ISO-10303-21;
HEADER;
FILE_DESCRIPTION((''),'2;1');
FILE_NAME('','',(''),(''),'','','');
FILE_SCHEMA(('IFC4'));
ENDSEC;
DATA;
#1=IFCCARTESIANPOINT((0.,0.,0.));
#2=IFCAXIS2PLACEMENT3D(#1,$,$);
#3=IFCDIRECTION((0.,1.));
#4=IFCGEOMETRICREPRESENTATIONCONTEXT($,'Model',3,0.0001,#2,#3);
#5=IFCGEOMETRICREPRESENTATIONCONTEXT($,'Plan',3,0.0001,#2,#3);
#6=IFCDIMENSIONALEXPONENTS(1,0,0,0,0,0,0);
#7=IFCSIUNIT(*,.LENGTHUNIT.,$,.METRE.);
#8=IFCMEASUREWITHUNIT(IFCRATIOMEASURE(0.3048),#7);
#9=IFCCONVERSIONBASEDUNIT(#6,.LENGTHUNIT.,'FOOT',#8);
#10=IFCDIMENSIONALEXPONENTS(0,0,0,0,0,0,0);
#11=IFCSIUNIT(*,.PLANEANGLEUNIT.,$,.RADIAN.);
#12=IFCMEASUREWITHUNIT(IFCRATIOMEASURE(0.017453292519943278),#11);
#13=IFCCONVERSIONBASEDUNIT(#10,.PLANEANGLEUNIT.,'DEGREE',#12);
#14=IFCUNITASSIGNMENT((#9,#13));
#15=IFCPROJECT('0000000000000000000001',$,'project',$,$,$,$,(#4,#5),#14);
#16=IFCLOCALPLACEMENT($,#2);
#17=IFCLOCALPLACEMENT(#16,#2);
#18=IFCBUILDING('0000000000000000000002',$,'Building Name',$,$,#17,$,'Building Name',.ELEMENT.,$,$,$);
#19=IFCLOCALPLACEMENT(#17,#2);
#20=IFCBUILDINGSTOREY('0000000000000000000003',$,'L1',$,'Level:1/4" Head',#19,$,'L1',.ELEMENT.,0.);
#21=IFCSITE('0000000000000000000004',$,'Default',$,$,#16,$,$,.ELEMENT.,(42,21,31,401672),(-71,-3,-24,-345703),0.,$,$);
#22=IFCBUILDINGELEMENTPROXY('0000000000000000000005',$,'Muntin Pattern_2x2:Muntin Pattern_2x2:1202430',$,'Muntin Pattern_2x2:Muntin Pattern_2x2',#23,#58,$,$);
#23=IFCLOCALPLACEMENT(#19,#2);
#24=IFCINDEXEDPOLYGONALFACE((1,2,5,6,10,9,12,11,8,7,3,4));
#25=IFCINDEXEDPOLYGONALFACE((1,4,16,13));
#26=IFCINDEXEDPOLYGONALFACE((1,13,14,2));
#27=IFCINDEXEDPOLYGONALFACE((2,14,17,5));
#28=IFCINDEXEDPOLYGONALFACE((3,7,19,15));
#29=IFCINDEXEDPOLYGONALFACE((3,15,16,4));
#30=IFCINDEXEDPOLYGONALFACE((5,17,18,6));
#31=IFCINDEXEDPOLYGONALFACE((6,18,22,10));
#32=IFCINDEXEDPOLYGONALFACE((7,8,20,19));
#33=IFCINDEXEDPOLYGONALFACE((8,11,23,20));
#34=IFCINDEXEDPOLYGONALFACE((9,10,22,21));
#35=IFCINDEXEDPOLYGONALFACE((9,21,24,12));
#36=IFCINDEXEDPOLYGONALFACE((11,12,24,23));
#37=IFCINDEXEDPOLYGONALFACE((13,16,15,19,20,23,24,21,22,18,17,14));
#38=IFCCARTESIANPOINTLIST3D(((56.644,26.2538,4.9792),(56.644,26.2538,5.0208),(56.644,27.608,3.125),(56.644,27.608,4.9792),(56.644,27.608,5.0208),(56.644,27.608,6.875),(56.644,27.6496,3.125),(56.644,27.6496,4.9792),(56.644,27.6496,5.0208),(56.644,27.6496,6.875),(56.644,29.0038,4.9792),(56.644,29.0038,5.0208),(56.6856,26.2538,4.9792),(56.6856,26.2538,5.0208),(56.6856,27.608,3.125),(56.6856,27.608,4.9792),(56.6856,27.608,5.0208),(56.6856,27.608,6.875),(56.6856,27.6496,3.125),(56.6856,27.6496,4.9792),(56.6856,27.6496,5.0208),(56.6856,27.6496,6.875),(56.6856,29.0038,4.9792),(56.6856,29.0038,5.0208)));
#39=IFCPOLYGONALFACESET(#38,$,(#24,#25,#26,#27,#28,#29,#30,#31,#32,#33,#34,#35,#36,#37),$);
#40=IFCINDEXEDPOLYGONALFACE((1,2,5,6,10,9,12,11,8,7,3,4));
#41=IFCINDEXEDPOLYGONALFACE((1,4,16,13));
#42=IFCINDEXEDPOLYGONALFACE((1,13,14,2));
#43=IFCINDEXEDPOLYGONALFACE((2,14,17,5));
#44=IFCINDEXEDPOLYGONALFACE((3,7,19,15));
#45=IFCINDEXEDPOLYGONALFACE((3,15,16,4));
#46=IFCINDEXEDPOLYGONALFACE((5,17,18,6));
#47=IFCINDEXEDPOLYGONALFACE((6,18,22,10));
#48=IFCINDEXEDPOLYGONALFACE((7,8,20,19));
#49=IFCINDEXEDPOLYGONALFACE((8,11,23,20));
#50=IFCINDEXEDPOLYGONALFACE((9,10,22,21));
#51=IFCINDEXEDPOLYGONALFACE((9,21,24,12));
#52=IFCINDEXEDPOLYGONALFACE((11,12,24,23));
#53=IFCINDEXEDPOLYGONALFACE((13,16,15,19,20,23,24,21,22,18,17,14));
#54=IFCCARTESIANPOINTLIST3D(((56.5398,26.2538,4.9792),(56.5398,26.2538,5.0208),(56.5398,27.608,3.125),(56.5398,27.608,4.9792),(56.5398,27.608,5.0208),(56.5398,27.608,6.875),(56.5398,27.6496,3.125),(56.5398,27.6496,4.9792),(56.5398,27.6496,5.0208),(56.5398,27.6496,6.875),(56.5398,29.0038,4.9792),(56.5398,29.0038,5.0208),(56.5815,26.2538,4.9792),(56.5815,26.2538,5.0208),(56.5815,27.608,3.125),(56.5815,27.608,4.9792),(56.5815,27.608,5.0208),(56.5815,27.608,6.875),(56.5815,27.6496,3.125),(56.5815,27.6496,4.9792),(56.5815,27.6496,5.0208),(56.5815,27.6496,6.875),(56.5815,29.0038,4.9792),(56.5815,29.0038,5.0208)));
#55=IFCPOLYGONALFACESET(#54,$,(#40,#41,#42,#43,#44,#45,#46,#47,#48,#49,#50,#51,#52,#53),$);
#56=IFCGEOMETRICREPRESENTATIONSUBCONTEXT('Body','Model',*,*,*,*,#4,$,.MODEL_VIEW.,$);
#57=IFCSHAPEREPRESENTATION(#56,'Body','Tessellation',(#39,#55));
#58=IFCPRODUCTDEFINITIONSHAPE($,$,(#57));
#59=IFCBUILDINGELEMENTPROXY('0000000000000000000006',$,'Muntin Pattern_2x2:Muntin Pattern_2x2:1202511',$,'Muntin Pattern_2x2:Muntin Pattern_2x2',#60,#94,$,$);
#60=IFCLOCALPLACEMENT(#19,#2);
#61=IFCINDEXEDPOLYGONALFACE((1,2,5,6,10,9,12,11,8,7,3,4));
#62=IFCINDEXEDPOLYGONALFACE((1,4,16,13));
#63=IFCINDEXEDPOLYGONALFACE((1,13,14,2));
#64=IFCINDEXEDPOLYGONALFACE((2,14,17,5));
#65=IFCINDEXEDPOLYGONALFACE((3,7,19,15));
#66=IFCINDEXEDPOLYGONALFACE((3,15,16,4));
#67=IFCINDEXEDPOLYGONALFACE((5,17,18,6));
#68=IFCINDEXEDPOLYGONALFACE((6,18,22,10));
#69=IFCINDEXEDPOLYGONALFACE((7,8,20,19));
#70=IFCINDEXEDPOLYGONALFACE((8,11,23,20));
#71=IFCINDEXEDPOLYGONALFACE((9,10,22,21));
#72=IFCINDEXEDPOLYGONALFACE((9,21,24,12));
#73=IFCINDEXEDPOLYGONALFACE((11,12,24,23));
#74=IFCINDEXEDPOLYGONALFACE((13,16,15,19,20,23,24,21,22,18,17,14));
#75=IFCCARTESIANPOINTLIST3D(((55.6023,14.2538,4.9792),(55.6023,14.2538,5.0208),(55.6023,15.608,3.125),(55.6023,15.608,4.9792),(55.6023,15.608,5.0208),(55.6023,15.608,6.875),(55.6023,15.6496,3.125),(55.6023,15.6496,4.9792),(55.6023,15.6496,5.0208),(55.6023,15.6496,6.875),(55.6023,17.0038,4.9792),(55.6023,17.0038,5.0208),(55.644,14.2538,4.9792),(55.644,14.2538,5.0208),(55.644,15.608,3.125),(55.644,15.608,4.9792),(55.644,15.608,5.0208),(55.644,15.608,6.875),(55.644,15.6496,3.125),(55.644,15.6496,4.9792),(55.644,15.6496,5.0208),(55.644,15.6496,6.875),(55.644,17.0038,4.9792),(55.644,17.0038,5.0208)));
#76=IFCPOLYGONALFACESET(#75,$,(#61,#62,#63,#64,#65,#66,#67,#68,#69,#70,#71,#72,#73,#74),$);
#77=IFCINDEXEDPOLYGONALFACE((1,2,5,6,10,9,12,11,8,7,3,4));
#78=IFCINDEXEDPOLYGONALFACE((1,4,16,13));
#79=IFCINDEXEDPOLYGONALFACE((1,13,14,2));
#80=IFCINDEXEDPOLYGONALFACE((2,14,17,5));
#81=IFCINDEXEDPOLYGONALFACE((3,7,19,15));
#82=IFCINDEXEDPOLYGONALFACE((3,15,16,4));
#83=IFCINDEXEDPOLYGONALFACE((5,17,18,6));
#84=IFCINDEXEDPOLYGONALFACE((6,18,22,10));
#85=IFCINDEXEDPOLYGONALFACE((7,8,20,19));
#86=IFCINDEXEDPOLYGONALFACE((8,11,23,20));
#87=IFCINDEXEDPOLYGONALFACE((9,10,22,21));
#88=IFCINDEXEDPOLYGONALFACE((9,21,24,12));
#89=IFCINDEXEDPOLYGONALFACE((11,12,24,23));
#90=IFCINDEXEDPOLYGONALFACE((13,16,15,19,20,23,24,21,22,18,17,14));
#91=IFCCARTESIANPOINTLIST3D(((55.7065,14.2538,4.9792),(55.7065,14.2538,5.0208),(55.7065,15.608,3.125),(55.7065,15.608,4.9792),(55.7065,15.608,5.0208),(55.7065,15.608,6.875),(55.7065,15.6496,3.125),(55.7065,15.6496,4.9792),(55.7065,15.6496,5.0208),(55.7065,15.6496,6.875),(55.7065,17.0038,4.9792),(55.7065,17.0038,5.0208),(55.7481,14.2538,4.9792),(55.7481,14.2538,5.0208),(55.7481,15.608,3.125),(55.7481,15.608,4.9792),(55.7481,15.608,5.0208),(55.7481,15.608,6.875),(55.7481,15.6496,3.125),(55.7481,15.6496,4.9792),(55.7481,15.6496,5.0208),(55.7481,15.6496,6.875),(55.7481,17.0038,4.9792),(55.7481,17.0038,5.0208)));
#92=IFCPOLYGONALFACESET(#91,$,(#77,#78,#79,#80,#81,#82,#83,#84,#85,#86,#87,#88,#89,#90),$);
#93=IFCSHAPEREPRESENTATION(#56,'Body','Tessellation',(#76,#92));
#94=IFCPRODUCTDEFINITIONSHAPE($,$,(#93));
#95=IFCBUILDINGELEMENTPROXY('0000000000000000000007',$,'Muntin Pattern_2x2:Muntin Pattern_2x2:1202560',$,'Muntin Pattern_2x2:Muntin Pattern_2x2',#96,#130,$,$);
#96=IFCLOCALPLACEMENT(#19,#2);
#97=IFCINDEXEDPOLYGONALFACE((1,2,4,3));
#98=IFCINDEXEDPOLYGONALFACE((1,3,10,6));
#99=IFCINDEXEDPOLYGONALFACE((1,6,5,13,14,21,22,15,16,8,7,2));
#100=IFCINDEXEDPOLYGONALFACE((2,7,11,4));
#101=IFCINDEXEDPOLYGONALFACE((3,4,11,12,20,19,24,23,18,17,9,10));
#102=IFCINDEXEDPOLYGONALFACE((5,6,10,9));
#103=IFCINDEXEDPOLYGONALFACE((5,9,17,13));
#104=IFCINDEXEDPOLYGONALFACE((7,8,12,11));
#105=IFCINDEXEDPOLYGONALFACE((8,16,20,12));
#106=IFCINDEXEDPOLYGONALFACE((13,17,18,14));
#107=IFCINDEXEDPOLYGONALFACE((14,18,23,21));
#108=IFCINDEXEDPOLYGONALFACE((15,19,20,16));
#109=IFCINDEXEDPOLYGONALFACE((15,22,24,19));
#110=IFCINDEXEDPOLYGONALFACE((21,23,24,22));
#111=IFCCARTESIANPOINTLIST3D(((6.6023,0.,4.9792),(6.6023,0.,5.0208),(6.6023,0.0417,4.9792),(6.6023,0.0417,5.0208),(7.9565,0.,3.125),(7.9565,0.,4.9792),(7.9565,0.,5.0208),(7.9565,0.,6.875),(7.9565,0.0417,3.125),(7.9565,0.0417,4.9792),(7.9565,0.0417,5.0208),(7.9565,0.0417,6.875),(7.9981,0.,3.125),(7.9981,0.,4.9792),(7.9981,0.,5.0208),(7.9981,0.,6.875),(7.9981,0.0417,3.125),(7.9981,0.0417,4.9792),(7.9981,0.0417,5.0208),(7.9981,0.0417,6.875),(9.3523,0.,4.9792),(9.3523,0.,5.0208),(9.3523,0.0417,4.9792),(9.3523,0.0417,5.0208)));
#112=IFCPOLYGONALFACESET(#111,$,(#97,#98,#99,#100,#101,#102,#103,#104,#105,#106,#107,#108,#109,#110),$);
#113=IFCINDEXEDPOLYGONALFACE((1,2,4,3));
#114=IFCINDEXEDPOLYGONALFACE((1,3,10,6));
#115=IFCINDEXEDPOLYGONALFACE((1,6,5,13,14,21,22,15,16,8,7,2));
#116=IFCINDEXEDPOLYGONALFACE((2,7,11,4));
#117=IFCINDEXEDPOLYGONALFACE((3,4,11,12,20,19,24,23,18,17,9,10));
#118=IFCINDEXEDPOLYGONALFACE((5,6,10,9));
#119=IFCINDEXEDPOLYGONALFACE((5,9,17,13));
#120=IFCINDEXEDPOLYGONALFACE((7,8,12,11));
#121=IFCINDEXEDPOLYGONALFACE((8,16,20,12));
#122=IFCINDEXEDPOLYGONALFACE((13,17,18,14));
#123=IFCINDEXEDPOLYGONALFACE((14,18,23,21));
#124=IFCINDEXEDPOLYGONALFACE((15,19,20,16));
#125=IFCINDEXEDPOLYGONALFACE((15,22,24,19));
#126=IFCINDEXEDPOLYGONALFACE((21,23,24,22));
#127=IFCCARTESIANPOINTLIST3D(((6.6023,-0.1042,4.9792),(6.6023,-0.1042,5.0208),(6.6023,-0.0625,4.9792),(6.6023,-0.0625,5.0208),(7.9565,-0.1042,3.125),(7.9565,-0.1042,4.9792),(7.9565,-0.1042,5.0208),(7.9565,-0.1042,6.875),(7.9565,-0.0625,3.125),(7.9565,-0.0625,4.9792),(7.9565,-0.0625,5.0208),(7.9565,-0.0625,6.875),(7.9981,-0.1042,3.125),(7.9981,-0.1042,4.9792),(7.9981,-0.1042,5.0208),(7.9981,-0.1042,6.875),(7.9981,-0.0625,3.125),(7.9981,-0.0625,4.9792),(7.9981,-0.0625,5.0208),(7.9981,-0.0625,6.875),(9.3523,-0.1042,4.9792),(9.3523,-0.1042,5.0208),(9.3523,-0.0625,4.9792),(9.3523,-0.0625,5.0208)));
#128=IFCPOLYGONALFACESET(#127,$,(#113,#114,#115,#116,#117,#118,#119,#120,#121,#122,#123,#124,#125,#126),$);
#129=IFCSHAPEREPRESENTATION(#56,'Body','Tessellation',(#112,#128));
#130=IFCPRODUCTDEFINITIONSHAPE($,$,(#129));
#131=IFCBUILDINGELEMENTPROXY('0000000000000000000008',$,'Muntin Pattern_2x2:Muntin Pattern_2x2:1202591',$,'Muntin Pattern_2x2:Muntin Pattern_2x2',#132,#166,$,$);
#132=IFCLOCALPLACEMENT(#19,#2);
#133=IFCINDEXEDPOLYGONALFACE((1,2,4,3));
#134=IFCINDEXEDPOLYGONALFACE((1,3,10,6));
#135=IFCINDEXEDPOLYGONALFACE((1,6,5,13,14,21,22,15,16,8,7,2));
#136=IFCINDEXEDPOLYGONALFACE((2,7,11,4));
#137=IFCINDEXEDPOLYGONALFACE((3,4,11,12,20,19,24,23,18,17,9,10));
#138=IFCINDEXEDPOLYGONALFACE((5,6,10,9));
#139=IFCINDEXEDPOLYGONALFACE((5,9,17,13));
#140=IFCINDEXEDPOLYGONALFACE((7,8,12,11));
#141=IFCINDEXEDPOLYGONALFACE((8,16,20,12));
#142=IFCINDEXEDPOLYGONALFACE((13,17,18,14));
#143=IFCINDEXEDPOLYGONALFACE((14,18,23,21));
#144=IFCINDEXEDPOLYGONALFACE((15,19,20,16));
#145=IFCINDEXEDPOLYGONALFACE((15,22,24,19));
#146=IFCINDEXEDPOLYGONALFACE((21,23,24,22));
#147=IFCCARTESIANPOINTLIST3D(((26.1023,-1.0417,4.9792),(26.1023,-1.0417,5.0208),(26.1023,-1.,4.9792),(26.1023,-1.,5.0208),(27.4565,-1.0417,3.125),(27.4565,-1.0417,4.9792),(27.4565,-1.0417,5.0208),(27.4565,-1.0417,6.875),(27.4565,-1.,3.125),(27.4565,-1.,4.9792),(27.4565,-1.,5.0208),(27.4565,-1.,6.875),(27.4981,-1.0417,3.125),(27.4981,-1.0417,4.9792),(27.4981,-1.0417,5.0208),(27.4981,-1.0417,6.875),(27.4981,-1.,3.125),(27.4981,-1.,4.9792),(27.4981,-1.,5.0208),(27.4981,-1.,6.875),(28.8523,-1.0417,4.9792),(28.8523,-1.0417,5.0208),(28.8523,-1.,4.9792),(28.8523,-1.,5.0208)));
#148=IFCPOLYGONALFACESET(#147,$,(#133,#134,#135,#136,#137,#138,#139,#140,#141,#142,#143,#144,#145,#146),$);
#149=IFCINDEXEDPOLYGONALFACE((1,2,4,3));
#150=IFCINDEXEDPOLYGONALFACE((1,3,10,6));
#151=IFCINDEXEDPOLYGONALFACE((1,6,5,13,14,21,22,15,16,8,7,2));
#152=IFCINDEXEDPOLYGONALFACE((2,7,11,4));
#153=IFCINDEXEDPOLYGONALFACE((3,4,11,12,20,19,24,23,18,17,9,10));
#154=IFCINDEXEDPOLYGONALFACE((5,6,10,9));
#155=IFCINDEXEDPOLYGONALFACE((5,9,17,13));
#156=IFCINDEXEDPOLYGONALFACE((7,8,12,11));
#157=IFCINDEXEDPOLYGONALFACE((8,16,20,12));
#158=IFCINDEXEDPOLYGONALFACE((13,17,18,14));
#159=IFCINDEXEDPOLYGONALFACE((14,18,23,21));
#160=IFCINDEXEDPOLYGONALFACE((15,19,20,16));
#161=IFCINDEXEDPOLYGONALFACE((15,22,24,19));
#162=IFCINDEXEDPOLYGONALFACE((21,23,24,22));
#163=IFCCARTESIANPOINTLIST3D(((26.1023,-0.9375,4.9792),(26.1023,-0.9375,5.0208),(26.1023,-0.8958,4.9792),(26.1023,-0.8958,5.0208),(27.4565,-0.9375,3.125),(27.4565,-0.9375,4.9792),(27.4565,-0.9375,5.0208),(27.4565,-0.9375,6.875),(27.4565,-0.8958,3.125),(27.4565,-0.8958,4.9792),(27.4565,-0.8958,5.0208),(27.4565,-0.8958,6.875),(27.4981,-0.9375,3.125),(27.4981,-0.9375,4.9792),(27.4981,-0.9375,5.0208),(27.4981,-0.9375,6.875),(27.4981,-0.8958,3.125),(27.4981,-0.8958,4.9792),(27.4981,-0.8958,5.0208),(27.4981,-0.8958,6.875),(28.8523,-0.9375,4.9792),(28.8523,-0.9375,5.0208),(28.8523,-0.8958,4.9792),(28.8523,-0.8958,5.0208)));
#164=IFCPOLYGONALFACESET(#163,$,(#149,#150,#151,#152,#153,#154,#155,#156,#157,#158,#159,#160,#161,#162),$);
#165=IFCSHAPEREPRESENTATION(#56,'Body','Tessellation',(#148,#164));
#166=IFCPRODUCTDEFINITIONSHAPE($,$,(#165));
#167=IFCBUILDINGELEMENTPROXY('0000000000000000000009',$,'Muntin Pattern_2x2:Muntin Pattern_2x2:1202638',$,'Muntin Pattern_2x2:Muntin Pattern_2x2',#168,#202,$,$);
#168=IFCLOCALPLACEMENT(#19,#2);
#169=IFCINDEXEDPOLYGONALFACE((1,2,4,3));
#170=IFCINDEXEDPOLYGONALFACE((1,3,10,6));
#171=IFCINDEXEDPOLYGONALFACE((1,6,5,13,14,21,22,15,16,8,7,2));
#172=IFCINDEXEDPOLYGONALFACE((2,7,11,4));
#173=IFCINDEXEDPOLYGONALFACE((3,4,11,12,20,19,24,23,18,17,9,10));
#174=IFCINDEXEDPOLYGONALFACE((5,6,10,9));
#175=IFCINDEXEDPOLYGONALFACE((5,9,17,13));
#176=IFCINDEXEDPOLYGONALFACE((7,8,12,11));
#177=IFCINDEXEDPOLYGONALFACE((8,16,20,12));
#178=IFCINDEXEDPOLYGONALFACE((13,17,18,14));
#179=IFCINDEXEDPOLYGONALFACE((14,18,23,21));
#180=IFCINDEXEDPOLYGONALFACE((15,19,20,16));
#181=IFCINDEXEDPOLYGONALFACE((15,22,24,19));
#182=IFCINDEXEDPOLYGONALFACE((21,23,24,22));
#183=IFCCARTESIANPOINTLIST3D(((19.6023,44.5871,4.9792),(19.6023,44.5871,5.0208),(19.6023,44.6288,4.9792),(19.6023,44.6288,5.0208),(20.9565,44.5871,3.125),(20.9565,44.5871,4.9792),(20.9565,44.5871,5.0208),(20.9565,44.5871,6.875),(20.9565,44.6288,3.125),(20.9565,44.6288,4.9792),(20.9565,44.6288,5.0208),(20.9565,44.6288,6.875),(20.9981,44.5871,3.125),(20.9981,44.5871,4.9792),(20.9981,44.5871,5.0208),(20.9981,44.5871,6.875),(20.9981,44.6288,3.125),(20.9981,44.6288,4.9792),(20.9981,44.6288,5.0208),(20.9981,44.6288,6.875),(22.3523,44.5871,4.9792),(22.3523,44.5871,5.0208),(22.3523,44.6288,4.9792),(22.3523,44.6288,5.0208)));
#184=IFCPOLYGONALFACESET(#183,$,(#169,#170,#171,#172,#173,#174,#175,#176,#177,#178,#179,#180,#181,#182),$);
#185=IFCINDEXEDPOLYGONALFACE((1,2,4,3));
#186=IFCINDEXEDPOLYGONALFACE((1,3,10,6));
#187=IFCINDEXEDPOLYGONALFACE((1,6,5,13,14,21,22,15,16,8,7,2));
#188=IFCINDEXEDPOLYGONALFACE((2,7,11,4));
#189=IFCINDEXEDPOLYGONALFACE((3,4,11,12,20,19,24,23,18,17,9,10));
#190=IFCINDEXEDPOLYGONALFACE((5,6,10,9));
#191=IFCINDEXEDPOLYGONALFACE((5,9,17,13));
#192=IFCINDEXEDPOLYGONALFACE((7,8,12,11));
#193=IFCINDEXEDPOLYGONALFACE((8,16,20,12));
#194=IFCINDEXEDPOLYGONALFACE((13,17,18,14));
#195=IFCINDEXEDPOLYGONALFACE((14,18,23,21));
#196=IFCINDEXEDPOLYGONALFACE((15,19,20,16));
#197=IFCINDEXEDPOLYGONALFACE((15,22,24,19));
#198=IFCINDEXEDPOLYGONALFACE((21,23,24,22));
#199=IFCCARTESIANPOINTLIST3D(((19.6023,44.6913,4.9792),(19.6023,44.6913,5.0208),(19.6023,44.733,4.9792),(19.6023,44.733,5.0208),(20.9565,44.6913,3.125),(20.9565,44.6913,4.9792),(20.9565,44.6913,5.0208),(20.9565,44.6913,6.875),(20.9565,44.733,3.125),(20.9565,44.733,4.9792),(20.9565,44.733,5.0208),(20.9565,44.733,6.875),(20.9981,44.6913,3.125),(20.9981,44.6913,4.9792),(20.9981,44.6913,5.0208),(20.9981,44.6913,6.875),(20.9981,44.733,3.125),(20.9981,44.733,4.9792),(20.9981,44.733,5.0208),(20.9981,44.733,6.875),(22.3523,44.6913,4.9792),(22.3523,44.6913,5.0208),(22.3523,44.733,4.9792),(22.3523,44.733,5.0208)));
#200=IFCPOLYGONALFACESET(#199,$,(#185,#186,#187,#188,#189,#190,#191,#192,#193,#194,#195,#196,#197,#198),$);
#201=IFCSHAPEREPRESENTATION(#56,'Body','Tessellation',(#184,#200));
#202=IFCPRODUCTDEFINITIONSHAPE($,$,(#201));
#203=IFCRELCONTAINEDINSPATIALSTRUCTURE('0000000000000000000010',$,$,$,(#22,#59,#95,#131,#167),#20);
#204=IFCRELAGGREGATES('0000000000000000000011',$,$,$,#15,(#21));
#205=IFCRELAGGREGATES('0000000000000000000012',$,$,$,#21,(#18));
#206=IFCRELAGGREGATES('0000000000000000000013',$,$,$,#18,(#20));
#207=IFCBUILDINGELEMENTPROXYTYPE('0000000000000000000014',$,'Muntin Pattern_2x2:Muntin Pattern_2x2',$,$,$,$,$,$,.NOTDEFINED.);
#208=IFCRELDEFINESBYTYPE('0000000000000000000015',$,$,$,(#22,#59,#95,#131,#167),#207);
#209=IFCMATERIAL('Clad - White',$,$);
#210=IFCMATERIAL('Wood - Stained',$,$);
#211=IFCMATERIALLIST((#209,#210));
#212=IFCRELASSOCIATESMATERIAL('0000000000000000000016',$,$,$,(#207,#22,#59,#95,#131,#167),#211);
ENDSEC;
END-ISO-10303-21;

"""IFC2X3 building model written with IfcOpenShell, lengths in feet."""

from ifc_helpers import new_model, entity, si_unit, converted_unit, direction, frame, origin, place, context, subcontext, project, spatial, polyline, outline, extrude, source, transform, mapped, material, material_list, type_object, type_shapes, element, save


model = new_model("IFC2X3")

# Units and contexts
model_context = context("Model", 3, precision=0.0001, world=origin(), true_north=direction((0.0, 1.0)))
plan_context = context("Plan", 3, precision=0.0001, world=origin(), true_north=direction((0.0, 1.0)))
body_context = subcontext(model_context, "Body", "Model", "MODEL_VIEW")
ifc_project = project(units=[converted_unit("LENGTHUNIT", "FOOT", entity("IfcRatioMeasure", 0.3048), si_unit("LENGTHUNIT", "METRE"), dimensions=[1, 0, 0, 0, 0, 0, 0]), converted_unit("PLANEANGLEUNIT", "DEGREE", entity("IfcRatioMeasure", 0.017453292519943278), si_unit("PLANEANGLEUNIT", "RADIAN"), dimensions=[0, 0, 0, 0, 0, 0, 0])], contexts=[model_context, plan_context])

# Site, building, storey
site_placement = place(None, origin())
site = spatial("IfcSite", under=ifc_project, at=site_placement, Name="Default", CompositionType="ELEMENT", RefLatitude=(42, 21, 31, 401672), RefLongitude=(-71, -3, -24, -345703), RefElevation=0.0)
building_placement = place(site_placement, origin())
building = spatial("IfcBuilding", under=site, at=building_placement, Name="Building Name", LongName="Building Name", CompositionType="ELEMENT")
storey_placement = place(building_placement, origin())
storey = spatial("IfcBuildingStorey", under=building, at=storey_placement, Name="L1", ObjectType="Level:1/4\" Head", LongName="L1", CompositionType="ELEMENT", Elevation=0.0)

# Building element proxies
ifc_material_1 = material(Name="Clad - White")
ifc_material_2 = material(Name="Wood - Stained")
ifc_material_list = material_list([ifc_material_1, ifc_material_2])
building_element_proxy_type_1 = type_object("IfcBuildingElementProxyType", Name="Muntin Pattern_2x2:Muntin Pattern_2x2", PredefinedType="NOTDEFINED", material=ifc_material_list)
shared_shape_1 = source(origin(), body_context, "Body", "SweptSolid", [
    extrude(outline(polyline([(0.0208, -0.0208), (1.875, -0.0208), (1.875, 0.0208), (0.0208, 0.0208), (0.0208, 1.375), (-0.0208, 1.375), (-0.0208, 0.0208), (-1.875, 0.0208), (-1.875, -0.0208), (-0.0208, -0.0208), (-0.0208, -1.375), (0.0208, -1.375), (0.0208, -0.0208)])), frame((0.0, -0.0729, 1.875), z_axis=(0.0, 1.0, 0.0), x_axis=(0.0, 0.0, 1.0)), (0.0, 0.0, 1.0), 0.0417),
    extrude(outline(polyline([(0.0208, -0.0208), (1.875, -0.0208), (1.875, 0.0208), (0.0208, 0.0208), (0.0208, 1.375), (-0.0208, 1.375), (-0.0208, 0.0208), (-1.875, 0.0208), (-1.875, -0.0208), (-0.0208, -0.0208), (-0.0208, -1.375), (0.0208, -1.375), (0.0208, -0.0208)])), frame((0.0, 0.0313, 1.875), z_axis=(0.0, 1.0, 0.0), x_axis=(0.0, 0.0, 1.0)), (0.0, 0.0, 1.0), 0.0417),
])
type_shapes(building_element_proxy_type_1, [shared_shape_1])
for number, where, z_axis, x_axis, name in (
    (1, (56.6127, 27.6288, 3.125), (0.0, 0.0, 1.0), (0.0, 1.0, 0.0), "Muntin Pattern_2x2:Muntin Pattern_2x2:1202430"),
    (2, (55.6752, 15.6288, 3.125), (0.0, 0.0, 1.0), (0.0, -1.0, 0.0), "Muntin Pattern_2x2:Muntin Pattern_2x2:1202511"),
    (3, (7.9773, -0.0312, 3.125), (0.0, 0.0, 1.0), (-1.0, 0.0, 0.0), "Muntin Pattern_2x2:Muntin Pattern_2x2:1202560"),
):
    element("IfcBuildingElementProxy", number, at=place(storey_placement, frame(where, z_axis=z_axis, x_axis=x_axis)), inside=storey, type_object=building_element_proxy_type_1, material=ifc_material_list, Name=name, ObjectType="Muntin Pattern_2x2:Muntin Pattern_2x2", context=body_context, shape_type="MappedRepresentation", body=[
        mapped(shared_shape_1, transform((0.0, 0.0, 0.0), scale=1.0)),
    ])
for number, where, name in (
    (4, (27.4773, -0.9688, 3.125), "Muntin Pattern_2x2:Muntin Pattern_2x2:1202591"),
    (5, (20.9773, 44.66, 3.125), "Muntin Pattern_2x2:Muntin Pattern_2x2:1202638"),
):
    element("IfcBuildingElementProxy", number, at=place(storey_placement, frame(where)), inside=storey, type_object=building_element_proxy_type_1, material=ifc_material_list, Name=name, ObjectType="Muntin Pattern_2x2:Muntin Pattern_2x2", context=body_context, shape_type="MappedRepresentation", body=[
        mapped(shared_shape_1, transform((0.0, 0.0, 0.0), scale=1.0)),
    ])

save(model, "model.ifc")
